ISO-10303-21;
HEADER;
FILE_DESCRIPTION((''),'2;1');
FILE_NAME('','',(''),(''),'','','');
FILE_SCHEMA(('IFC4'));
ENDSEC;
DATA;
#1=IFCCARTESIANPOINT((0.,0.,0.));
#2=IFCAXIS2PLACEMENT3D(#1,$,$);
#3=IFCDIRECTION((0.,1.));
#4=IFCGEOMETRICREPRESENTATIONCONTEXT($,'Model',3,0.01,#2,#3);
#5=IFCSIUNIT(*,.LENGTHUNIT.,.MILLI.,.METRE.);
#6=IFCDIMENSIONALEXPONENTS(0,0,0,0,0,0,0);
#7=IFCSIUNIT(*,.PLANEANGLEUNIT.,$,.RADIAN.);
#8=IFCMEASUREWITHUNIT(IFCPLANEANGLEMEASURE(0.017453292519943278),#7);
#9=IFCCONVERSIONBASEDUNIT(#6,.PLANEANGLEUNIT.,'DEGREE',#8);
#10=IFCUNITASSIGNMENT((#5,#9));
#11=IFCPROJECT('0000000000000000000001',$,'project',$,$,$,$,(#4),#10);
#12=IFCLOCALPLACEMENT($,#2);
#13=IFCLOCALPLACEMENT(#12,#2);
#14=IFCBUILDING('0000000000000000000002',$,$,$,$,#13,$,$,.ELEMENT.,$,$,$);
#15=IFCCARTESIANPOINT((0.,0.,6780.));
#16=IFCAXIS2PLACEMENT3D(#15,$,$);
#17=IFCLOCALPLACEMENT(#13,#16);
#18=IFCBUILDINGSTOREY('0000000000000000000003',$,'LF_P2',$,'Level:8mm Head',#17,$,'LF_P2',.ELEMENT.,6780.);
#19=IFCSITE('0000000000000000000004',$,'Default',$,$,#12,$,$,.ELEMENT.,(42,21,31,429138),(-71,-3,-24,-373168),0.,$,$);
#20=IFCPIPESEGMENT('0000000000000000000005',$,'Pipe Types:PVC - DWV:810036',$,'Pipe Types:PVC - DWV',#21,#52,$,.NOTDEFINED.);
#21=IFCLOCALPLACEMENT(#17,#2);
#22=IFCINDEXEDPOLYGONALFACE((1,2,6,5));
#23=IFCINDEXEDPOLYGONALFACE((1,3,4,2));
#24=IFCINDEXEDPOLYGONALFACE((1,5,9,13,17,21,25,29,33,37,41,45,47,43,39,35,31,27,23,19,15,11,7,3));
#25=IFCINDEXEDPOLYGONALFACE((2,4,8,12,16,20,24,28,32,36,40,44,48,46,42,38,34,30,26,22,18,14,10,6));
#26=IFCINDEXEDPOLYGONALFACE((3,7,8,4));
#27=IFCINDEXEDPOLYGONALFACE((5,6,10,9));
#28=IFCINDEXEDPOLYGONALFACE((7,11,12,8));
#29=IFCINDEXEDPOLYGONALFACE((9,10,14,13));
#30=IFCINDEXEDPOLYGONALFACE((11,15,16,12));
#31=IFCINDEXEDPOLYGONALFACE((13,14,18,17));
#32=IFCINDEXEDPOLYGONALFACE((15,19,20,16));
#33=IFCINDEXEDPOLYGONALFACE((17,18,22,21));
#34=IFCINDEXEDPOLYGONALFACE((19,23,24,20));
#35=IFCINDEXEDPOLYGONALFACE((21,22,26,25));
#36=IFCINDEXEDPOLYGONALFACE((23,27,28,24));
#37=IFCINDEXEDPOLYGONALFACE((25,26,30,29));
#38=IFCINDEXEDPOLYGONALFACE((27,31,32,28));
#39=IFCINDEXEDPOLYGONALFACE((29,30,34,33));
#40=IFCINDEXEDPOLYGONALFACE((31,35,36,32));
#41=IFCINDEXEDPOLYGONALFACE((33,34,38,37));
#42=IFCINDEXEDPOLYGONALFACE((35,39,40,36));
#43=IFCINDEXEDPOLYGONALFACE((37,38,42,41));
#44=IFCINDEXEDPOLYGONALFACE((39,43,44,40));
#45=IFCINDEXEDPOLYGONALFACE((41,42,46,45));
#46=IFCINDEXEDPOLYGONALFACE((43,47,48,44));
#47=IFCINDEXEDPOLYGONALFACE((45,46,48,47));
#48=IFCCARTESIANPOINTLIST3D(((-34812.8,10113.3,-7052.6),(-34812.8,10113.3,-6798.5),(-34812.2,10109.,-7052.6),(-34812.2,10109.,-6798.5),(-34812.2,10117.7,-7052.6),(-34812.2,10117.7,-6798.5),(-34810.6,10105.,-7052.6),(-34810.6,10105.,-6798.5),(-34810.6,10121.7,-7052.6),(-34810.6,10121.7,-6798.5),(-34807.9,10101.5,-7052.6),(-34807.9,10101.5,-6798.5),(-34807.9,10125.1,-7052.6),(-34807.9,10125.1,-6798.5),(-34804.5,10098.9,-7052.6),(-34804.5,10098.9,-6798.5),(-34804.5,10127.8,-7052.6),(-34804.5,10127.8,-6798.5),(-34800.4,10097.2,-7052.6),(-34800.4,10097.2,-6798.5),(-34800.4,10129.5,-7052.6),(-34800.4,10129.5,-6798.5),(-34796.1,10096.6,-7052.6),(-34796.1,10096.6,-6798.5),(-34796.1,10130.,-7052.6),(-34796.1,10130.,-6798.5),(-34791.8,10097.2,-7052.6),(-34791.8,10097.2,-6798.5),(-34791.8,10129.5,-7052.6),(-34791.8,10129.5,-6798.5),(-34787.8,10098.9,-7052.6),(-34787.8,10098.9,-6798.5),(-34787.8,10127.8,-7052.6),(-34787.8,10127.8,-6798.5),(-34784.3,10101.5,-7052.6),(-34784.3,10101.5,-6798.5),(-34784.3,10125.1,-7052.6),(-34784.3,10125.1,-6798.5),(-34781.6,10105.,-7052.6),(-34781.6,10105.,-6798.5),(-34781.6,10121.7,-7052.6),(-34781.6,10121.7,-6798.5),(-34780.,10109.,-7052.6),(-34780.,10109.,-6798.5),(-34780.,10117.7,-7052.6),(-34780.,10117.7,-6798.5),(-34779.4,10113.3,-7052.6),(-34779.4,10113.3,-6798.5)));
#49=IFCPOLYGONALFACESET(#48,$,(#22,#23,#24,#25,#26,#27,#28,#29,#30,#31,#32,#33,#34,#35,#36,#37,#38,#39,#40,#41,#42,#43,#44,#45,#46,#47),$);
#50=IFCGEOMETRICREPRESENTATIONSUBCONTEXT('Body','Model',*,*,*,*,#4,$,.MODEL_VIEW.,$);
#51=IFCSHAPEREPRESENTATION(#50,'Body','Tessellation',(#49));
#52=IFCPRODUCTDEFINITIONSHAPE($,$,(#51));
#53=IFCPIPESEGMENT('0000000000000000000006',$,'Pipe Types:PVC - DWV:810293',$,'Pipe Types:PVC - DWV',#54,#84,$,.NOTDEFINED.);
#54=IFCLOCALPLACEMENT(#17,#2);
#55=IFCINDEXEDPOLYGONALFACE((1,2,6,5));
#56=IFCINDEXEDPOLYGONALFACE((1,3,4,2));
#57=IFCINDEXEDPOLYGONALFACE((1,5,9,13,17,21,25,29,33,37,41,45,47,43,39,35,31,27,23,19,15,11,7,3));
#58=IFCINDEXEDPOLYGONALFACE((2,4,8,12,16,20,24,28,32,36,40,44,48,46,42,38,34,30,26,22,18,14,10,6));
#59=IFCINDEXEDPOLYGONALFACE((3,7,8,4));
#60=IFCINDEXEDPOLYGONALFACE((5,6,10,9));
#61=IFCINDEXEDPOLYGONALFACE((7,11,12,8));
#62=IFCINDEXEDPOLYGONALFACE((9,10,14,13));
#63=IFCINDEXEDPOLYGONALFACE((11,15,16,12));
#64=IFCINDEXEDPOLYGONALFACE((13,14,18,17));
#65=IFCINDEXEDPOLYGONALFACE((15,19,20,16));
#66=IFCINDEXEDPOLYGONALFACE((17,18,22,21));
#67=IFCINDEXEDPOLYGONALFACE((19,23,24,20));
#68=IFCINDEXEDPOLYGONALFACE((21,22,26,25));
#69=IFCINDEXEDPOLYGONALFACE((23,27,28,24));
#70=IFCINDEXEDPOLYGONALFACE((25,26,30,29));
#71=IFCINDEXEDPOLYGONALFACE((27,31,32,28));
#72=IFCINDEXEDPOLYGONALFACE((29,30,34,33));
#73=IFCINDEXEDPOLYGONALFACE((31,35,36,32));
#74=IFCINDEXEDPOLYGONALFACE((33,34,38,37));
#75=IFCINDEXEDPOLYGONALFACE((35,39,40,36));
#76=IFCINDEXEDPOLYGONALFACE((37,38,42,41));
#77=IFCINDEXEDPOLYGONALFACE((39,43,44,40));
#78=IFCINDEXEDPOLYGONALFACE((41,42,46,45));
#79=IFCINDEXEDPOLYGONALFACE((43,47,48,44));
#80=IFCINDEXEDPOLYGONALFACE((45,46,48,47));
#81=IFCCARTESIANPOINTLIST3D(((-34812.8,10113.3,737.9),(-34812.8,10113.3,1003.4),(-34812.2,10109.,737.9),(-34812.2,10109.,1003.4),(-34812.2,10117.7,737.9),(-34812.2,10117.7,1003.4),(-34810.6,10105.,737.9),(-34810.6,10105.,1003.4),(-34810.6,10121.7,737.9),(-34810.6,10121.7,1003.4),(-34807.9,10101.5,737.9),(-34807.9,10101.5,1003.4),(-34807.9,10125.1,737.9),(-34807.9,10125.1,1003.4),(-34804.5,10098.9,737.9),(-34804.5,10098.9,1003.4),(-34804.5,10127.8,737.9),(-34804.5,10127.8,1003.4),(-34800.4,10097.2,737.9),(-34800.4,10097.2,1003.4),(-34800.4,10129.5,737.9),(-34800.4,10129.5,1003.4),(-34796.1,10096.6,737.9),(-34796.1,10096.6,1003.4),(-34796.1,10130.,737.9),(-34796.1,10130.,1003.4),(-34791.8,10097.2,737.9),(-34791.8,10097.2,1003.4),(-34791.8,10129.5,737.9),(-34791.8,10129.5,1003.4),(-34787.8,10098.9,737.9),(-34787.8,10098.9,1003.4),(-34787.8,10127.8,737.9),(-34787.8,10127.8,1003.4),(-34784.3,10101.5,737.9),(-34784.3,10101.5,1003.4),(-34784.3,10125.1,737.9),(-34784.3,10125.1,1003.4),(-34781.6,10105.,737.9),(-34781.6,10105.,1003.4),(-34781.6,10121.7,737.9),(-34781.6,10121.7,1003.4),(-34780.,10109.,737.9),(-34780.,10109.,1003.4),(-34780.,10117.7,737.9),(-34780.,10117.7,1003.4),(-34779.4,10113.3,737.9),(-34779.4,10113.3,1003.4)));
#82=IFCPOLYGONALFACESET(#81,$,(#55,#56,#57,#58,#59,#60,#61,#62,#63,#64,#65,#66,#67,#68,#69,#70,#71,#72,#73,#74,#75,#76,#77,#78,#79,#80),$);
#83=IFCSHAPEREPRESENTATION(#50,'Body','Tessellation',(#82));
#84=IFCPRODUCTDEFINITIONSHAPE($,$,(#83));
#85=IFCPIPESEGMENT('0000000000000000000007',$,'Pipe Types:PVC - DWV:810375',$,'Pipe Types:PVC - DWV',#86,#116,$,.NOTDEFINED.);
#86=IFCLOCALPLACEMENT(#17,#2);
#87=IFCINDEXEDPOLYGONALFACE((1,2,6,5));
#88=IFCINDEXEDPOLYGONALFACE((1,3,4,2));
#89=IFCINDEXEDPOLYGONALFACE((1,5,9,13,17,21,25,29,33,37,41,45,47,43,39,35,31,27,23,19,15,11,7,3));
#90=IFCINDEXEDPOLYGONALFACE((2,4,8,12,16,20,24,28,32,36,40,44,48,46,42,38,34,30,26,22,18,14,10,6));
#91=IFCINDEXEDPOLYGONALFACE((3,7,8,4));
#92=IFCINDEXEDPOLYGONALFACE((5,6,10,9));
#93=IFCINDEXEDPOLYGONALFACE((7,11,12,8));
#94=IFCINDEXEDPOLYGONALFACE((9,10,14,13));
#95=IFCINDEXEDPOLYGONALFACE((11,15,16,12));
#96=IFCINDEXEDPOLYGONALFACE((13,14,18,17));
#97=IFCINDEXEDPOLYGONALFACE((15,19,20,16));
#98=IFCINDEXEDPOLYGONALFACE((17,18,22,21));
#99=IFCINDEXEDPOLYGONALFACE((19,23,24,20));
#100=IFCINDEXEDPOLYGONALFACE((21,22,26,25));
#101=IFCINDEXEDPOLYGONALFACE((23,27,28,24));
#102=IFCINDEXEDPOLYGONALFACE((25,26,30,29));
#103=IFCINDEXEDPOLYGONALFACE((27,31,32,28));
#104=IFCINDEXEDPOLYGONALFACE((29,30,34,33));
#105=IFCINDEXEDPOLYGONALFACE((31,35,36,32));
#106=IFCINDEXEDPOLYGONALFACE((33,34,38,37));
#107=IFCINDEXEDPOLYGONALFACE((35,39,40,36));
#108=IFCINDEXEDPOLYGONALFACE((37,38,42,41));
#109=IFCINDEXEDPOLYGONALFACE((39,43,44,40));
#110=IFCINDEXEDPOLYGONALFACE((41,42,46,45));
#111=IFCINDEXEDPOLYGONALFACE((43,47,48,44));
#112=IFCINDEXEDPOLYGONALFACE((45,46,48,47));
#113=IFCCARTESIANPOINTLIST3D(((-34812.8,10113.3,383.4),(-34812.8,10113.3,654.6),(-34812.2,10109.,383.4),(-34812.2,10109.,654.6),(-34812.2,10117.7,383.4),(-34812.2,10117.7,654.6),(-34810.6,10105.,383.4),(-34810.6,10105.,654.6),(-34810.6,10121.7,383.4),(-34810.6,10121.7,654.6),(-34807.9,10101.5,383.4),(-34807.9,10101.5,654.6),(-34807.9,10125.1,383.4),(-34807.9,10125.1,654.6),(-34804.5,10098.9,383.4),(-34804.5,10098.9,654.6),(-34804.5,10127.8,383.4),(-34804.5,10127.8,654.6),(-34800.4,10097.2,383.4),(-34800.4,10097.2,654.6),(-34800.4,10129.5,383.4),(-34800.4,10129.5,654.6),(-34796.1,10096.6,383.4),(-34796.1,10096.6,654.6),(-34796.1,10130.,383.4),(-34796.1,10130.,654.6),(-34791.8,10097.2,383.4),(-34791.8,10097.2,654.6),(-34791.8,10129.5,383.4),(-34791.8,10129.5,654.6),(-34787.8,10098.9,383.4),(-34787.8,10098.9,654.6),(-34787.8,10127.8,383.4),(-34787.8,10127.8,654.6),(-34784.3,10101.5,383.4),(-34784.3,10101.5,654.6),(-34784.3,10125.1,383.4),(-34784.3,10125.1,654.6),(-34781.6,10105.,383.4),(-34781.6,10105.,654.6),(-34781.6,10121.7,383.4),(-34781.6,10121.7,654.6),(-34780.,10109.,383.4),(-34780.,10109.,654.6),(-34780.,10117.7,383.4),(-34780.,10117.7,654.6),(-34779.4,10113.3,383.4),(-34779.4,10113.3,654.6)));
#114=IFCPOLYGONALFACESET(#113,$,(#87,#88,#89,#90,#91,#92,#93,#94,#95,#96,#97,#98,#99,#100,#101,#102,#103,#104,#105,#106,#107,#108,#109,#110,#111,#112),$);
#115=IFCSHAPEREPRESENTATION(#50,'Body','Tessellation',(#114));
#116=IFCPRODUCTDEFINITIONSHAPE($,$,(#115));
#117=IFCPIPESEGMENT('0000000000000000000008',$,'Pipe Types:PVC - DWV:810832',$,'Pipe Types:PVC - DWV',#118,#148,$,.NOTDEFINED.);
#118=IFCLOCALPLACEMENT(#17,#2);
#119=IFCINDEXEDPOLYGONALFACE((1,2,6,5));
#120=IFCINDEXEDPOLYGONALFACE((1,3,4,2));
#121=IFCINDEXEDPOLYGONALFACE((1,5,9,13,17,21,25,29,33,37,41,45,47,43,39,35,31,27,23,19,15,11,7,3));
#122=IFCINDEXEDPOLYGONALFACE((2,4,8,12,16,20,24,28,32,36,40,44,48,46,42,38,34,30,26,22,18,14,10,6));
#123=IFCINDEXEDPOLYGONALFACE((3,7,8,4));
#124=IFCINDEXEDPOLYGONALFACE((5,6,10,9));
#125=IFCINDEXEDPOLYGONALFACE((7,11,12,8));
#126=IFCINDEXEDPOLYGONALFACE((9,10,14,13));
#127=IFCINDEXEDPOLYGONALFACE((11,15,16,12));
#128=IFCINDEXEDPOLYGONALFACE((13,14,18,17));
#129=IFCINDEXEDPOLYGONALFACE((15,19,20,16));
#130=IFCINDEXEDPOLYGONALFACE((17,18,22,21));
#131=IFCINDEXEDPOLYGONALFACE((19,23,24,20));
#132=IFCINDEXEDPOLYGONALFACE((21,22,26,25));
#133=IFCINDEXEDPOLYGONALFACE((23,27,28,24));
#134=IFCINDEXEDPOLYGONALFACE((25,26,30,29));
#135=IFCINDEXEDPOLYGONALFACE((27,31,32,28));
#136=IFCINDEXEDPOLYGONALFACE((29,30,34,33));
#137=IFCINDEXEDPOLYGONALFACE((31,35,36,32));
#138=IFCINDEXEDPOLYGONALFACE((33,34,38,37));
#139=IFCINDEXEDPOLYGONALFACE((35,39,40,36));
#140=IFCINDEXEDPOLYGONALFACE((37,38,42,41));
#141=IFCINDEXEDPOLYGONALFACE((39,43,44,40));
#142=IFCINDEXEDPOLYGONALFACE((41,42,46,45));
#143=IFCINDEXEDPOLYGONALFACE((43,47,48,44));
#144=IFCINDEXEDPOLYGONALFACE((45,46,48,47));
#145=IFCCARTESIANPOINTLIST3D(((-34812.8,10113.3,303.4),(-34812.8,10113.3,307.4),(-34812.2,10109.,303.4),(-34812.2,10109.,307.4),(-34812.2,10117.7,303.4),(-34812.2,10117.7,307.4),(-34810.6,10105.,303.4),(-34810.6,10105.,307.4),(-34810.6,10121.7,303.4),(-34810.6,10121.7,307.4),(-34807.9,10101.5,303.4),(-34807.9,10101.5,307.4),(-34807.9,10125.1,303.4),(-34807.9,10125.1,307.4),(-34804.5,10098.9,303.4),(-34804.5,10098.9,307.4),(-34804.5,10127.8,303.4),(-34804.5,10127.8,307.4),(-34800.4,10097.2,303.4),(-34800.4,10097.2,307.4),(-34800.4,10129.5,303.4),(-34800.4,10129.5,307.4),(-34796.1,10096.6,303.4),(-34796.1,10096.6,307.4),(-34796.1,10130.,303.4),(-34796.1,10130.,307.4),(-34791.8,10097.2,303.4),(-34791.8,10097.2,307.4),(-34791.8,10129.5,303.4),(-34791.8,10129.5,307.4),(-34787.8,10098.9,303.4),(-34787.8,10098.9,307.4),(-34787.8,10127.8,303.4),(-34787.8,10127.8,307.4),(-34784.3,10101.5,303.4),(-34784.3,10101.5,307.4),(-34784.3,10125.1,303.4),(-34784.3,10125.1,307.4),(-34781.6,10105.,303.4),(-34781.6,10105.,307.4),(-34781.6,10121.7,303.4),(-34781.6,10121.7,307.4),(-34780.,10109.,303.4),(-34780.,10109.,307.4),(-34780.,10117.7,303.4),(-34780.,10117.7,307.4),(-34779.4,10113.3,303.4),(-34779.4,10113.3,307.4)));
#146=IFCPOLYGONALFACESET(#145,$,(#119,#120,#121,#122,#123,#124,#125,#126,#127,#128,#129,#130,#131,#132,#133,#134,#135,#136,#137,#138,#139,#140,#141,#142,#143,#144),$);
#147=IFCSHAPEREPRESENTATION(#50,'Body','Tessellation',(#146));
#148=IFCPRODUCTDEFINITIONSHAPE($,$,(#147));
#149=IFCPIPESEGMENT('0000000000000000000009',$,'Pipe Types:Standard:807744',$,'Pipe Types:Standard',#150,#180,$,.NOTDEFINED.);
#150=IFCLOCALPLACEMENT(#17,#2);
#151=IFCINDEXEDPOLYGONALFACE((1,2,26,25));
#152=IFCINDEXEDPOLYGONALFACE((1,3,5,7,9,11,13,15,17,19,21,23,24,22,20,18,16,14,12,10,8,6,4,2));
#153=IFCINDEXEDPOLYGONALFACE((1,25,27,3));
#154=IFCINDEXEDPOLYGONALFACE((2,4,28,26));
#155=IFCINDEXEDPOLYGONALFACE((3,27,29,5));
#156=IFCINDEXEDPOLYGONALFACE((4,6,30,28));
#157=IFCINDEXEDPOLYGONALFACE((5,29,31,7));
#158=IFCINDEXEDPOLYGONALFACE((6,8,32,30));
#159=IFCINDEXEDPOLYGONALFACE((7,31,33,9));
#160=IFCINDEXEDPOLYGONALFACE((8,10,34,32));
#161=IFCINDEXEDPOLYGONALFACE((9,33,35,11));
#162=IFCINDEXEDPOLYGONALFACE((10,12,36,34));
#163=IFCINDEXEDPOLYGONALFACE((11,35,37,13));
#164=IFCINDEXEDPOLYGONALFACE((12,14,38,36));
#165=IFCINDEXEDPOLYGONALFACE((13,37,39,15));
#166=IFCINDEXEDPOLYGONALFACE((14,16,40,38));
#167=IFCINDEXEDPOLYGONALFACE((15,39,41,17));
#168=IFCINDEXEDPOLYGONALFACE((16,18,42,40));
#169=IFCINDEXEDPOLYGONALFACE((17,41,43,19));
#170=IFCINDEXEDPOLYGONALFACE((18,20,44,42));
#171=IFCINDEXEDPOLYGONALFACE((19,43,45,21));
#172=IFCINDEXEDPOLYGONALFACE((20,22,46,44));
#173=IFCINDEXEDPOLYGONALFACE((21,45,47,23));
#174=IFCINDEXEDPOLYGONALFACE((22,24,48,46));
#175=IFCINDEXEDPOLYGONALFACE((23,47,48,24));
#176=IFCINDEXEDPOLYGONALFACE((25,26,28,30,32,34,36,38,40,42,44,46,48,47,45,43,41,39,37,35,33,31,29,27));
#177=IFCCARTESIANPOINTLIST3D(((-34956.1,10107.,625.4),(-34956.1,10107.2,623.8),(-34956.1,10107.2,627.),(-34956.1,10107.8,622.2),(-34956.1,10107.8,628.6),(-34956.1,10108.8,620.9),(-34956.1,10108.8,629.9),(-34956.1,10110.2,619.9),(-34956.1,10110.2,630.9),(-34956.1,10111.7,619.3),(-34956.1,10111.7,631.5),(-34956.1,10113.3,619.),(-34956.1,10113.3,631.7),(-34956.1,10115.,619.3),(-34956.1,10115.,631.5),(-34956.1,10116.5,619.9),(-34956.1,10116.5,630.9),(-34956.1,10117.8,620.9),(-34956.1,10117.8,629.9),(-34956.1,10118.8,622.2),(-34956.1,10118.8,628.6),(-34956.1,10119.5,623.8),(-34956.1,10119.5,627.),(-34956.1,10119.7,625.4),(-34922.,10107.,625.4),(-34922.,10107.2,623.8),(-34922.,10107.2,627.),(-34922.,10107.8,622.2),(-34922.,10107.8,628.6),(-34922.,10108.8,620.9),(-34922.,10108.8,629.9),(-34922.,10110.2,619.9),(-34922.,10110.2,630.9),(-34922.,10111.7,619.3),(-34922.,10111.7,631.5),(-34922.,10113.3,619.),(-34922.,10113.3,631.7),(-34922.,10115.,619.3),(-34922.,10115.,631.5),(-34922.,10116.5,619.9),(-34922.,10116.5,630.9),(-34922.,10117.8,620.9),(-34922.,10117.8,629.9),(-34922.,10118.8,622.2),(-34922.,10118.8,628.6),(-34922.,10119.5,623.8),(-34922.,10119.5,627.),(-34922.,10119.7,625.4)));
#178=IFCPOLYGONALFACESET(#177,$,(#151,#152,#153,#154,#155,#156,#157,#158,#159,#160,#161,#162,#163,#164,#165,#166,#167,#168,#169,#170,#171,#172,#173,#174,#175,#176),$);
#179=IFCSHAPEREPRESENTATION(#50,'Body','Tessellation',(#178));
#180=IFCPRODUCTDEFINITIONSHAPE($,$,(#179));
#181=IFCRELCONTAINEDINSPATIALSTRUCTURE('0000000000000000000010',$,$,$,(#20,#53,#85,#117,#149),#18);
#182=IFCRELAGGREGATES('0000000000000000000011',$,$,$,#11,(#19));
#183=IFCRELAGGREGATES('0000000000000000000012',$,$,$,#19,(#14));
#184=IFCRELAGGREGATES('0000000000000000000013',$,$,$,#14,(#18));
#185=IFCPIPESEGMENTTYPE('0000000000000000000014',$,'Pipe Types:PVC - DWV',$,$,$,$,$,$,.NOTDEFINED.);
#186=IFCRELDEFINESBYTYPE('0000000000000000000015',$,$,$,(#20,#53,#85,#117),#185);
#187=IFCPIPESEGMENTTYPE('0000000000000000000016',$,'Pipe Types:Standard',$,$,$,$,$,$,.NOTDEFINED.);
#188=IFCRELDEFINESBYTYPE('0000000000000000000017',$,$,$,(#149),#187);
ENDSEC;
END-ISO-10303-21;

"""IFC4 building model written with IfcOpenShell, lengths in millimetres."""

from ifc_helpers import new_model, entity, si_unit, converted_unit, direction, frame, origin, place, context, subcontext, project, spatial, arc, indexed_curve, outline, extrude, type_object, element, save


model = new_model("IFC4")

# Units and contexts
model_context = context("Model", 3, precision=0.01, world=origin(), true_north=direction((0.0, 1.0)))
body_context = subcontext(model_context, "Body", "Model", "MODEL_VIEW")
ifc_project = project(units=[si_unit("LENGTHUNIT", "METRE", prefix="MILLI"), converted_unit("PLANEANGLEUNIT", "DEGREE", entity("IfcPlaneAngleMeasure", 0.017453292519943278), si_unit("PLANEANGLEUNIT", "RADIAN"), dimensions=[0, 0, 0, 0, 0, 0, 0])], contexts=[model_context])

# Site, building, storey
site_placement = place(None, origin())
site = spatial("IfcSite", under=ifc_project, at=site_placement, Name="Default", CompositionType="ELEMENT", RefLatitude=(42, 21, 31, 429138), RefLongitude=(-71, -3, -24, -373168), RefElevation=0.0)
building_placement = place(site_placement, origin())
building = spatial("IfcBuilding", under=site, at=building_placement, CompositionType="ELEMENT")
storey_placement = place(building_placement, frame((0.0, 0.0, 6780.0)))
storey = spatial("IfcBuildingStorey", under=building, at=storey_placement, Name="LF_P2", ObjectType="Level:8mm Head", LongName="LF_P2", CompositionType="ELEMENT", Elevation=6780.0)

# Pipe segments
pipe_segment_type_1 = type_object("IfcPipeSegmentType", Name="Pipe Types:PVC - DWV", PredefinedType="NOTDEFINED")
pipe_segment_1_placement = place(storey_placement, origin())
element("IfcPipeSegment", 1, at=pipe_segment_1_placement, inside=storey, type_object=pipe_segment_type_1, Name="Pipe Types:PVC - DWV:810036", ObjectType="Pipe Types:PVC - DWV", PredefinedType="NOTDEFINED", context=body_context, shape_type="SweptSolid", body=[
    extrude(outline(indexed_curve([(16.7, 0.0), (11.8, 11.8), (0.0, 16.7), (-11.8, 11.8), (-16.7, 0.0), (-11.8, -11.8), (0.0, -16.7), (11.8, -11.8)], segments=[arc(1, 2, 3), arc(3, 4, 5), arc(5, 6, 7), arc(7, 8, 1)], self_intersect=False)), frame((-34796.1, 10113.3, -7052.6)), (0.0, 0.0, 1.0), 254.1),
])
pipe_segment_2_placement = place(storey_placement, origin())
element("IfcPipeSegment", 2, at=pipe_segment_2_placement, inside=storey, type_object=pipe_segment_type_1, Name="Pipe Types:PVC - DWV:810293", ObjectType="Pipe Types:PVC - DWV", PredefinedType="NOTDEFINED", context=body_context, shape_type="SweptSolid", body=[
    extrude(outline(indexed_curve([(16.7, 0.0), (11.8, 11.8), (0.0, 16.7), (-11.8, 11.8), (-16.7, 0.0), (-11.8, -11.8), (0.0, -16.7), (11.8, -11.8)], segments=[arc(1, 2, 3), arc(3, 4, 5), arc(5, 6, 7), arc(7, 8, 1)], self_intersect=False)), frame((-34796.1, 10113.3, 737.9), z_axis=(0.0, 0.0, 1.0), x_axis=(-1.0, 0.0, 0.0)), (0.0, 0.0, 1.0), 265.5),
])
pipe_segment_3_placement = place(storey_placement, origin())
element("IfcPipeSegment", 3, at=pipe_segment_3_placement, inside=storey, type_object=pipe_segment_type_1, Name="Pipe Types:PVC - DWV:810375", ObjectType="Pipe Types:PVC - DWV", PredefinedType="NOTDEFINED", context=body_context, shape_type="SweptSolid", body=[
    extrude(outline(indexed_curve([(16.7, 0.0), (11.8, 11.8), (0.0, 16.7), (-11.8, 11.8), (-16.7, 0.0), (-11.8, -11.8), (0.0, -16.7), (11.8, -11.8)], segments=[arc(1, 2, 3), arc(3, 4, 5), arc(5, 6, 7), arc(7, 8, 1)], self_intersect=False)), frame((-34796.1, 10113.3, 383.4), z_axis=(0.0, 0.0, 1.0), x_axis=(-1.0, 0.0, 0.0)), (0.0, 0.0, 1.0), 271.2),
])
pipe_segment_4_placement = place(storey_placement, origin())
element("IfcPipeSegment", 4, at=pipe_segment_4_placement, inside=storey, type_object=pipe_segment_type_1, Name="Pipe Types:PVC - DWV:810832", ObjectType="Pipe Types:PVC - DWV", PredefinedType="NOTDEFINED", context=body_context, shape_type="SweptSolid", body=[
    extrude(outline(indexed_curve([(16.7, 0.0), (11.8, 11.8), (0.0, 16.7), (-11.8, 11.8), (-16.7, 0.0), (-11.8, -11.8), (0.0, -16.7), (11.8, -11.8)], segments=[arc(1, 2, 3), arc(3, 4, 5), arc(5, 6, 7), arc(7, 8, 1)], self_intersect=False)), frame((-34796.1, 10113.3, 303.4)), (0.0, 0.0, 1.0), 4.0),
])
pipe_segment_type_2 = type_object("IfcPipeSegmentType", Name="Pipe Types:Standard", PredefinedType="NOTDEFINED")
pipe_segment_5_placement = place(storey_placement, origin())
element("IfcPipeSegment", 5, at=pipe_segment_5_placement, inside=storey, type_object=pipe_segment_type_2, Name="Pipe Types:Standard:807744", ObjectType="Pipe Types:Standard", PredefinedType="NOTDEFINED", context=body_context, shape_type="SweptSolid", body=[
    extrude(outline(indexed_curve([(6.4, 0.0), (4.5, 4.5), (0.0, 6.3), (-4.5, 4.5), (-6.4, 0.0), (-4.5, -4.5), (0.0, -6.3), (4.5, -4.5)], segments=[arc(1, 2, 3), arc(3, 4, 5), arc(5, 6, 7), arc(7, 8, 1)], self_intersect=False)), frame((-34956.1, 10113.3, 625.4), z_axis=(1.0, 0.0, 0.0), x_axis=(0.0, -1.0, 0.0)), (0.0, 0.0, 1.0), 34.1),
])

save(model, "model.ifc")
